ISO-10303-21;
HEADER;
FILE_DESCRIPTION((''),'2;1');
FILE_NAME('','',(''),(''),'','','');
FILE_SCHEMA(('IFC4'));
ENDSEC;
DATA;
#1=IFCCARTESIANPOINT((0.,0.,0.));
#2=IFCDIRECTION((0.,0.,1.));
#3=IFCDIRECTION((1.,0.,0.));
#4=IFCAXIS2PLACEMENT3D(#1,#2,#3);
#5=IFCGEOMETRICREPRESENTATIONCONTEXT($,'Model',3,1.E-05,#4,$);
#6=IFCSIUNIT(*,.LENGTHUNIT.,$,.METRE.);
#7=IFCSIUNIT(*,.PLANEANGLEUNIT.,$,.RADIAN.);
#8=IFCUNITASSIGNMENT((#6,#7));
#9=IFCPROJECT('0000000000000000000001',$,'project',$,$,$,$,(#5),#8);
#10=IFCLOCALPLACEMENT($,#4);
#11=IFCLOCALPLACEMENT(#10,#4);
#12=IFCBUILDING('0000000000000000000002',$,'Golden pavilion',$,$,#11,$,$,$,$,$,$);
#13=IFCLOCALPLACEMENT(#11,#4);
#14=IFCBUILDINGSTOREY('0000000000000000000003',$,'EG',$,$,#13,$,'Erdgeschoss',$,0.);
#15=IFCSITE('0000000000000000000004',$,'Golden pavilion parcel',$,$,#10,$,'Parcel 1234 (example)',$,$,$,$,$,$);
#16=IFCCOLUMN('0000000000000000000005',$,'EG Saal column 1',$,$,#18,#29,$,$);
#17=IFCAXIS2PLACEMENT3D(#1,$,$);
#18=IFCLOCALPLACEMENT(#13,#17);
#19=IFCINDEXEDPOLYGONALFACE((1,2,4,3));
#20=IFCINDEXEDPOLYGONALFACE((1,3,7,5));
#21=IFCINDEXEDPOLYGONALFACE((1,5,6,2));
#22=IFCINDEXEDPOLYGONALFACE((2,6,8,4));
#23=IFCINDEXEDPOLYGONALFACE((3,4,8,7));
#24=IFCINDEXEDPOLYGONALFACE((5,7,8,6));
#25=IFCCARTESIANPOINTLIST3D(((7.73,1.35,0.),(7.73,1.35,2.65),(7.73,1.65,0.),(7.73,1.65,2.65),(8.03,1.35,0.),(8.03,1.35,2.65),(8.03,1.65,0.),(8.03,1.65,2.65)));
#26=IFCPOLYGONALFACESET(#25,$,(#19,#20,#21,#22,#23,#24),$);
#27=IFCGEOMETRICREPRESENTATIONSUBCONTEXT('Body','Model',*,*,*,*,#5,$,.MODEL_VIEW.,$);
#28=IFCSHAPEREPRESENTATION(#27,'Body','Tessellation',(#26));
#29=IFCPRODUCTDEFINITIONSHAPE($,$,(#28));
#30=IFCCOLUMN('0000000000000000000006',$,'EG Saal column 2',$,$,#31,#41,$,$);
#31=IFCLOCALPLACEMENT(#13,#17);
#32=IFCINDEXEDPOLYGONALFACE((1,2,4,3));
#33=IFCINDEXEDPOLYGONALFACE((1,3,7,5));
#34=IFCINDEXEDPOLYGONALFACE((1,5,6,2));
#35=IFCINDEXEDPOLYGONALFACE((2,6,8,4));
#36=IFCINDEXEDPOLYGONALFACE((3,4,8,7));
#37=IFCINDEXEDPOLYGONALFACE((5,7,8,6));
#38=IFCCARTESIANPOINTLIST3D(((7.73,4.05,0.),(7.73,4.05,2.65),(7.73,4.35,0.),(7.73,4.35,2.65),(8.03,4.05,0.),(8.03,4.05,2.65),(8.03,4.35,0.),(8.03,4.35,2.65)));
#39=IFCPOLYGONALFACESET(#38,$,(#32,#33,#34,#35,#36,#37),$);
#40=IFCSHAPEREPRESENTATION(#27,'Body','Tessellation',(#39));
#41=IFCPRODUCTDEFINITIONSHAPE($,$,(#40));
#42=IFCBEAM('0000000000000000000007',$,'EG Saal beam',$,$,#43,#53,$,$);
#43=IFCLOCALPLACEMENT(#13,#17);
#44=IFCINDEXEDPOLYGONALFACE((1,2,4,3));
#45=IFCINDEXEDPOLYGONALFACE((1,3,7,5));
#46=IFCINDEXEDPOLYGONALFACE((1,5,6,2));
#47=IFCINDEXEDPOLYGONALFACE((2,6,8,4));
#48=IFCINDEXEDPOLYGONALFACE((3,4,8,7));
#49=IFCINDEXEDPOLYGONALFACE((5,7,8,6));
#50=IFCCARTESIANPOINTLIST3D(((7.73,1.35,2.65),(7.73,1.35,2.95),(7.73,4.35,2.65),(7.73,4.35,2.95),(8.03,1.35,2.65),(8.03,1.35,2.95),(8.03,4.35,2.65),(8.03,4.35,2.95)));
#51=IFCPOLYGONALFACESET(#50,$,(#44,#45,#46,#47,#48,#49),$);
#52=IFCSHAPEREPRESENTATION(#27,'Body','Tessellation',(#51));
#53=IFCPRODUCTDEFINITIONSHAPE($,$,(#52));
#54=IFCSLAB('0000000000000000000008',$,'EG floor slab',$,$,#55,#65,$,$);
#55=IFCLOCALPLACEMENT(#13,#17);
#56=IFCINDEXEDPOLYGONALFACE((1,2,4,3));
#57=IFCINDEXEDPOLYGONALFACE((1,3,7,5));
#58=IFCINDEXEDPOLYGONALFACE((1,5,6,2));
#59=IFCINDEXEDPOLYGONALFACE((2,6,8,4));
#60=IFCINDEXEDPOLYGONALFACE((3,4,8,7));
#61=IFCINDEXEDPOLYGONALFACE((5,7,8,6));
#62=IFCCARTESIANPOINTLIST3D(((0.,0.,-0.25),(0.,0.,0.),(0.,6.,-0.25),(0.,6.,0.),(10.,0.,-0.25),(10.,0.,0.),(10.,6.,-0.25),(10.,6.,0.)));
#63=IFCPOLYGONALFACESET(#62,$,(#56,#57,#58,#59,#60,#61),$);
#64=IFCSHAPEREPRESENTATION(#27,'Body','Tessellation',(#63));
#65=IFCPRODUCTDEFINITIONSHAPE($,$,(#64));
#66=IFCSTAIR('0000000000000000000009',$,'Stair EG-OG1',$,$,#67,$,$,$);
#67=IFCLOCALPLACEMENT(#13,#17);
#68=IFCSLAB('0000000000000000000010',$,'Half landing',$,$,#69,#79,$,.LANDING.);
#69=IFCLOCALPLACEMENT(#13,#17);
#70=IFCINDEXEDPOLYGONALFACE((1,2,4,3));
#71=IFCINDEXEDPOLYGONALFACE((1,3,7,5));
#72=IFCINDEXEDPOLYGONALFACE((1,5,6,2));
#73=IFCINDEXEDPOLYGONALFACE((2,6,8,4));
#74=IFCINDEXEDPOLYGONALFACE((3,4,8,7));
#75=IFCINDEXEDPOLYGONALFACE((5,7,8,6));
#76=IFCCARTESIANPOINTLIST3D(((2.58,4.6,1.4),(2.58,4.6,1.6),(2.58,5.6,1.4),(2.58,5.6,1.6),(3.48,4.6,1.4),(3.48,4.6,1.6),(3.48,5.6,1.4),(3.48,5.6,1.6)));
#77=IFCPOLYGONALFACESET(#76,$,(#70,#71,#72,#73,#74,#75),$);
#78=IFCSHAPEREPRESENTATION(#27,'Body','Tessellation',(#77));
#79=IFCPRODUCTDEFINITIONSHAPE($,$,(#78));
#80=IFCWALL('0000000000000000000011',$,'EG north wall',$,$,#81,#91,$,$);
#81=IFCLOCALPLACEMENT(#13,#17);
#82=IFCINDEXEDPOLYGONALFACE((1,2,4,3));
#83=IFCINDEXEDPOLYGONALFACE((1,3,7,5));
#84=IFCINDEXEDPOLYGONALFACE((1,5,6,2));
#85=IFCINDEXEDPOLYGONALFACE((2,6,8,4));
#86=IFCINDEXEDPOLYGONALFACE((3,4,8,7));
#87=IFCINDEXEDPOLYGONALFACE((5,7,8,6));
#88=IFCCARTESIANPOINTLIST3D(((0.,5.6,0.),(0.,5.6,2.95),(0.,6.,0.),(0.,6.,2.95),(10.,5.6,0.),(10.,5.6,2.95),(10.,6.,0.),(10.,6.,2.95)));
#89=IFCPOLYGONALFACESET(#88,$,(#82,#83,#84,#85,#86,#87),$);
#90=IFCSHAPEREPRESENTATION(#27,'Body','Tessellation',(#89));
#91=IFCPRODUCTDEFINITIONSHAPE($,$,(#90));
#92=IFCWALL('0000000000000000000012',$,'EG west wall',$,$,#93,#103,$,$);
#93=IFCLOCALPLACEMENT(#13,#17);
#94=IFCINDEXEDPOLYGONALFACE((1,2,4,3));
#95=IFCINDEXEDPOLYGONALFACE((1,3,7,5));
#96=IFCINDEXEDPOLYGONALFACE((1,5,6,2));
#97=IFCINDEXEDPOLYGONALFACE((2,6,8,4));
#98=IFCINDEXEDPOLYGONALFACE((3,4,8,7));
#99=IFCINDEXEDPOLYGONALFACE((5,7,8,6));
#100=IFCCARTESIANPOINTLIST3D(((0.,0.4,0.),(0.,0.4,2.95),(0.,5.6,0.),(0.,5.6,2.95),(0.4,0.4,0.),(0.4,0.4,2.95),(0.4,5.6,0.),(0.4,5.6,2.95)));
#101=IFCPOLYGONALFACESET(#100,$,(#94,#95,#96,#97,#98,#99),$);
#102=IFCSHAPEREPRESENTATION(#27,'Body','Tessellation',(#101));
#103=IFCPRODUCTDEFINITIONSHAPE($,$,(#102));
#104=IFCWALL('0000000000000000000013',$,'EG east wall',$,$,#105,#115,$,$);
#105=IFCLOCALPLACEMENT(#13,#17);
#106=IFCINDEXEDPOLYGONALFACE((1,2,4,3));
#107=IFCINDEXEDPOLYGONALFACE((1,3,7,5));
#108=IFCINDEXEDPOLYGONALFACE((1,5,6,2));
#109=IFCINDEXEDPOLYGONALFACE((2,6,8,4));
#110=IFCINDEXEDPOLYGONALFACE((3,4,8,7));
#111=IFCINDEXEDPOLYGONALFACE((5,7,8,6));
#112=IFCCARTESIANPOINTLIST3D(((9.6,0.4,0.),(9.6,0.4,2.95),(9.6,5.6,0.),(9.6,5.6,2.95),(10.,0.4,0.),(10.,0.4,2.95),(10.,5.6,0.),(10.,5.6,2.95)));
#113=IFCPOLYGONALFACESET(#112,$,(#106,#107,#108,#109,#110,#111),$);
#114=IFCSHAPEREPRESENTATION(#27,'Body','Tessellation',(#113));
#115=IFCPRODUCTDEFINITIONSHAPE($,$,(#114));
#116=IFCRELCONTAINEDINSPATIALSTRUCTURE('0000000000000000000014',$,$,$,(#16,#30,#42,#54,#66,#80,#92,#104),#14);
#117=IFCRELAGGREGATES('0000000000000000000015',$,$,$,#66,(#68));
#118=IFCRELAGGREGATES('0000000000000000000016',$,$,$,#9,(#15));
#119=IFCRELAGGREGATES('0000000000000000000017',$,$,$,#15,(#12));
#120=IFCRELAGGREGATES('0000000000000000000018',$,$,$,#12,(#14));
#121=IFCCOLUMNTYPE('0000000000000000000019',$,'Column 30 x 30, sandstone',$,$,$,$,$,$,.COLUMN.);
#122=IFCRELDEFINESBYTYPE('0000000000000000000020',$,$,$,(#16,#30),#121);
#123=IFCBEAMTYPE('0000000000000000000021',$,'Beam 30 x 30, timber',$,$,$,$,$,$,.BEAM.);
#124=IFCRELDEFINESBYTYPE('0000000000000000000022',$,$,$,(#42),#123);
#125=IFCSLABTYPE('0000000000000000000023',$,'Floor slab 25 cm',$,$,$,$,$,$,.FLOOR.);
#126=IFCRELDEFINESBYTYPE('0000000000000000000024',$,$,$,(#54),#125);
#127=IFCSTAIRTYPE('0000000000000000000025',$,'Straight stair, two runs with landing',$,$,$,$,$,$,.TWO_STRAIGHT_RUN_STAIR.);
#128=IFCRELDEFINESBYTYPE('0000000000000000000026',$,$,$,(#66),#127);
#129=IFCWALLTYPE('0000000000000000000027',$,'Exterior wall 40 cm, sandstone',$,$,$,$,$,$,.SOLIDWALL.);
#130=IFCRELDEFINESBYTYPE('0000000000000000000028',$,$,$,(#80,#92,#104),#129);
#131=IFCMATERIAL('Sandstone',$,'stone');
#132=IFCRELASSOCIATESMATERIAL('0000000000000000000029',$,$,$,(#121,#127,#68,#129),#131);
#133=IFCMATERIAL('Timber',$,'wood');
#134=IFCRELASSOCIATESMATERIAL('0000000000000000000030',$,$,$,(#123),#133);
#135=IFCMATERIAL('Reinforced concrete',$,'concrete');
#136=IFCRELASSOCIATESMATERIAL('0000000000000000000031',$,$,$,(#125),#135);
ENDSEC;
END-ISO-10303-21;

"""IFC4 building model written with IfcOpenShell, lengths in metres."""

from ifc_helpers import new_model, si_unit, frame, origin_with_axes, place, context, subcontext, project, spatial, line, indexed_curve, outline, extrude, source, transform, mapped, material, type_object, type_shapes, element, aggregate, save


model = new_model("IFC4")

# Units and contexts
model_context = context("Model", 3, precision=1e-05, world=origin_with_axes())
body_context = subcontext(model_context, "Body", "Model", "MODEL_VIEW")
ifc_project = project(units=[si_unit("LENGTHUNIT", "METRE"), si_unit("PLANEANGLEUNIT", "RADIAN")], contexts=[model_context])

# Site, building, storey
site_placement = place(None, origin_with_axes())
site = spatial("IfcSite", under=ifc_project, at=site_placement, Name="Golden pavilion parcel", LongName="Parcel 1234 (example)")
building_placement = place(site_placement, origin_with_axes())
building = spatial("IfcBuilding", under=site, at=building_placement, Name="Golden pavilion")
storey_placement = place(building_placement, origin_with_axes())
storey = spatial("IfcBuildingStorey", under=building, at=storey_placement, Name="EG", LongName="Erdgeschoss", Elevation=0.0)

# Columns
ifc_material_1 = material(Name="Sandstone", Category="stone")
column_type = type_object("IfcColumnType", Name="Column 30 x 30, sandstone", PredefinedType="COLUMN", material=ifc_material_1)
shared_shape_1 = source(origin_with_axes(), body_context, "Body", "SweptSolid", [
    extrude(outline(indexed_curve([(0.0, 0.0), (0.3, 0.0), (0.3, 0.3), (0.0, 0.3)], segments=[line(1, 2, 3, 4, 1)])), origin_with_axes(), (0.0, 0.0, 1.0), 2.65),
])
type_shapes(column_type, [shared_shape_1])
for number, where, z_axis, x_axis, name in (
    (1, (7.73, 1.35, 0.0), (0.0, 0.0, 1.0), (1.0, 0.0, 0.0), "EG Saal column 1"),
    (2, (7.73, 4.05, 0.0), (0.0, 0.0, 1.0), (1.0, 0.0, 0.0), "EG Saal column 2"),
):
    element("IfcColumn", number, at=place(storey_placement, frame(where, z_axis=z_axis, x_axis=x_axis)), inside=storey, type_object=column_type, Name=name, context=body_context, shape_type="MappedRepresentation", body=[
        mapped(shared_shape_1, transform((0.0, 0.0, 0.0), x_axis=(1.0, 0.0, 0.0), y_axis=(0.0, 1.0, 0.0), z_axis=(0.0, 0.0, 1.0), scale=1.0)),
    ])

# Beam
ifc_material_2 = material(Name="Timber", Category="wood")
beam_type = type_object("IfcBeamType", Name="Beam 30 x 30, timber", PredefinedType="BEAM", material=ifc_material_2)
shared_shape_2 = source(origin_with_axes(), body_context, "Body", "SweptSolid", [
    extrude(outline(indexed_curve([(0.0, 0.0), (0.3, 0.0), (0.3, 3.0), (0.0, 3.0)], segments=[line(1, 2, 3, 4, 1)])), origin_with_axes(), (0.0, 0.0, 1.0), 0.3),
])
type_shapes(beam_type, [shared_shape_2])
beam_placement = place(storey_placement, frame((7.73, 1.35, 2.65), z_axis=(0.0, 0.0, 1.0), x_axis=(1.0, 0.0, 0.0)))
element("IfcBeam", 3, at=beam_placement, inside=storey, type_object=beam_type, Name="EG Saal beam", context=body_context, shape_type="MappedRepresentation", body=[
    mapped(shared_shape_2, transform((0.0, 0.0, 0.0), x_axis=(1.0, 0.0, 0.0), y_axis=(0.0, 1.0, 0.0), z_axis=(0.0, 0.0, 1.0), scale=1.0)),
])

# Slab
ifc_material_3 = material(Name="Reinforced concrete", Category="concrete")
slab_type = type_object("IfcSlabType", Name="Floor slab 25 cm", PredefinedType="FLOOR", material=ifc_material_3)
slab_1_placement = place(storey_placement, frame((0.0, 0.0, -0.25), z_axis=(0.0, 0.0, 1.0), x_axis=(1.0, 0.0, 0.0)))
element("IfcSlab", 4, at=slab_1_placement, inside=storey, type_object=slab_type, Name="EG floor slab", context=body_context, shape_type="SweptSolid", body=[
    extrude(outline(indexed_curve([(0.0, 0.0), (10.0, 0.0), (10.0, 6.0), (0.0, 6.0)], segments=[line(1, 2, 3, 4, 1)])), origin_with_axes(), (0.0, 0.0, 1.0), 0.25),
])

# Stair, slab
stair_type = type_object("IfcStairType", Name="Straight stair, two runs with landing", PredefinedType="TWO_STRAIGHT_RUN_STAIR", material=ifc_material_1)
stair_placement = place(storey_placement, frame((0.5, 4.6, 0.0), z_axis=(0.0, 0.0, 1.0), x_axis=(1.0, 0.0, 0.0)))
stair = element("IfcStair", 5, at=stair_placement, inside=storey, type_object=stair_type, Name="Stair EG-OG1")
slab_2_placement = place(stair_placement, frame((2.08, 0.0, 1.6), z_axis=(0.0, 0.0, 1.0), x_axis=(1.0, 0.0, 0.0)))
slab_2 = element("IfcSlab", 6, at=slab_2_placement, material=ifc_material_1, Name="Half landing", PredefinedType="LANDING", context=body_context, shape_type="SweptSolid", body=[
    extrude(outline(indexed_curve([(0.0, 0.0), (0.9, 0.0), (0.9, 1.0), (0.0, 1.0)], segments=[line(1, 2, 3, 4, 1)])), frame((0.0, 0.0, -0.2), z_axis=(0.0, 0.0, 1.0), x_axis=(1.0, 0.0, 0.0)), (0.0, 0.0, 1.0), 0.2),
])

# Shared definitions
wall_type_1 = type_object("IfcWallType", Name="Exterior wall 40 cm, sandstone", PredefinedType="SOLIDWALL", material=ifc_material_1)

# Walls
wall_1_placement = place(storey_placement, frame((10.0, 6.0, 0.0), z_axis=(0.0, 0.0, 1.0), x_axis=(-1.0, 0.0, 0.0)))
element("IfcWall", 7, at=wall_1_placement, inside=storey, type_object=wall_type_1, Name="EG north wall", context=body_context, shape_type="SweptSolid", body=[
    extrude(outline(indexed_curve([(0.0, 0.0), (0.0, 0.4), (10.0, 0.4), (10.0, 0.0), (0.0, 0.0)], self_intersect=False)), origin_with_axes(), (0.0, 0.0, 1.0), 2.95),
])
for number, where, z_axis, x_axis, name in (
    (8, (0.0, 5.6, 0.0), (0.0, 0.0, 1.0), (0.0, -1.0, 0.0), "EG west wall"),
    (9, (10.0, 0.4, 0.0), (0.0, 0.0, 1.0), (0.0, 1.0, 0.0), "EG east wall"),
):
    element("IfcWall", number, at=place(storey_placement, frame(where, z_axis=z_axis, x_axis=x_axis)), inside=storey, type_object=wall_type_1, Name=name, context=body_context, shape_type="SweptSolid", body=[
        extrude(outline(indexed_curve([(0.0, 0.0), (0.0, 0.4), (5.2, 0.4), (5.2, 0.0), (0.0, 0.0)], self_intersect=False)), origin_with_axes(), (0.0, 0.0, 1.0), 2.95),
    ])

aggregate(stair, [slab_2])

save(model, "model.ifc")
